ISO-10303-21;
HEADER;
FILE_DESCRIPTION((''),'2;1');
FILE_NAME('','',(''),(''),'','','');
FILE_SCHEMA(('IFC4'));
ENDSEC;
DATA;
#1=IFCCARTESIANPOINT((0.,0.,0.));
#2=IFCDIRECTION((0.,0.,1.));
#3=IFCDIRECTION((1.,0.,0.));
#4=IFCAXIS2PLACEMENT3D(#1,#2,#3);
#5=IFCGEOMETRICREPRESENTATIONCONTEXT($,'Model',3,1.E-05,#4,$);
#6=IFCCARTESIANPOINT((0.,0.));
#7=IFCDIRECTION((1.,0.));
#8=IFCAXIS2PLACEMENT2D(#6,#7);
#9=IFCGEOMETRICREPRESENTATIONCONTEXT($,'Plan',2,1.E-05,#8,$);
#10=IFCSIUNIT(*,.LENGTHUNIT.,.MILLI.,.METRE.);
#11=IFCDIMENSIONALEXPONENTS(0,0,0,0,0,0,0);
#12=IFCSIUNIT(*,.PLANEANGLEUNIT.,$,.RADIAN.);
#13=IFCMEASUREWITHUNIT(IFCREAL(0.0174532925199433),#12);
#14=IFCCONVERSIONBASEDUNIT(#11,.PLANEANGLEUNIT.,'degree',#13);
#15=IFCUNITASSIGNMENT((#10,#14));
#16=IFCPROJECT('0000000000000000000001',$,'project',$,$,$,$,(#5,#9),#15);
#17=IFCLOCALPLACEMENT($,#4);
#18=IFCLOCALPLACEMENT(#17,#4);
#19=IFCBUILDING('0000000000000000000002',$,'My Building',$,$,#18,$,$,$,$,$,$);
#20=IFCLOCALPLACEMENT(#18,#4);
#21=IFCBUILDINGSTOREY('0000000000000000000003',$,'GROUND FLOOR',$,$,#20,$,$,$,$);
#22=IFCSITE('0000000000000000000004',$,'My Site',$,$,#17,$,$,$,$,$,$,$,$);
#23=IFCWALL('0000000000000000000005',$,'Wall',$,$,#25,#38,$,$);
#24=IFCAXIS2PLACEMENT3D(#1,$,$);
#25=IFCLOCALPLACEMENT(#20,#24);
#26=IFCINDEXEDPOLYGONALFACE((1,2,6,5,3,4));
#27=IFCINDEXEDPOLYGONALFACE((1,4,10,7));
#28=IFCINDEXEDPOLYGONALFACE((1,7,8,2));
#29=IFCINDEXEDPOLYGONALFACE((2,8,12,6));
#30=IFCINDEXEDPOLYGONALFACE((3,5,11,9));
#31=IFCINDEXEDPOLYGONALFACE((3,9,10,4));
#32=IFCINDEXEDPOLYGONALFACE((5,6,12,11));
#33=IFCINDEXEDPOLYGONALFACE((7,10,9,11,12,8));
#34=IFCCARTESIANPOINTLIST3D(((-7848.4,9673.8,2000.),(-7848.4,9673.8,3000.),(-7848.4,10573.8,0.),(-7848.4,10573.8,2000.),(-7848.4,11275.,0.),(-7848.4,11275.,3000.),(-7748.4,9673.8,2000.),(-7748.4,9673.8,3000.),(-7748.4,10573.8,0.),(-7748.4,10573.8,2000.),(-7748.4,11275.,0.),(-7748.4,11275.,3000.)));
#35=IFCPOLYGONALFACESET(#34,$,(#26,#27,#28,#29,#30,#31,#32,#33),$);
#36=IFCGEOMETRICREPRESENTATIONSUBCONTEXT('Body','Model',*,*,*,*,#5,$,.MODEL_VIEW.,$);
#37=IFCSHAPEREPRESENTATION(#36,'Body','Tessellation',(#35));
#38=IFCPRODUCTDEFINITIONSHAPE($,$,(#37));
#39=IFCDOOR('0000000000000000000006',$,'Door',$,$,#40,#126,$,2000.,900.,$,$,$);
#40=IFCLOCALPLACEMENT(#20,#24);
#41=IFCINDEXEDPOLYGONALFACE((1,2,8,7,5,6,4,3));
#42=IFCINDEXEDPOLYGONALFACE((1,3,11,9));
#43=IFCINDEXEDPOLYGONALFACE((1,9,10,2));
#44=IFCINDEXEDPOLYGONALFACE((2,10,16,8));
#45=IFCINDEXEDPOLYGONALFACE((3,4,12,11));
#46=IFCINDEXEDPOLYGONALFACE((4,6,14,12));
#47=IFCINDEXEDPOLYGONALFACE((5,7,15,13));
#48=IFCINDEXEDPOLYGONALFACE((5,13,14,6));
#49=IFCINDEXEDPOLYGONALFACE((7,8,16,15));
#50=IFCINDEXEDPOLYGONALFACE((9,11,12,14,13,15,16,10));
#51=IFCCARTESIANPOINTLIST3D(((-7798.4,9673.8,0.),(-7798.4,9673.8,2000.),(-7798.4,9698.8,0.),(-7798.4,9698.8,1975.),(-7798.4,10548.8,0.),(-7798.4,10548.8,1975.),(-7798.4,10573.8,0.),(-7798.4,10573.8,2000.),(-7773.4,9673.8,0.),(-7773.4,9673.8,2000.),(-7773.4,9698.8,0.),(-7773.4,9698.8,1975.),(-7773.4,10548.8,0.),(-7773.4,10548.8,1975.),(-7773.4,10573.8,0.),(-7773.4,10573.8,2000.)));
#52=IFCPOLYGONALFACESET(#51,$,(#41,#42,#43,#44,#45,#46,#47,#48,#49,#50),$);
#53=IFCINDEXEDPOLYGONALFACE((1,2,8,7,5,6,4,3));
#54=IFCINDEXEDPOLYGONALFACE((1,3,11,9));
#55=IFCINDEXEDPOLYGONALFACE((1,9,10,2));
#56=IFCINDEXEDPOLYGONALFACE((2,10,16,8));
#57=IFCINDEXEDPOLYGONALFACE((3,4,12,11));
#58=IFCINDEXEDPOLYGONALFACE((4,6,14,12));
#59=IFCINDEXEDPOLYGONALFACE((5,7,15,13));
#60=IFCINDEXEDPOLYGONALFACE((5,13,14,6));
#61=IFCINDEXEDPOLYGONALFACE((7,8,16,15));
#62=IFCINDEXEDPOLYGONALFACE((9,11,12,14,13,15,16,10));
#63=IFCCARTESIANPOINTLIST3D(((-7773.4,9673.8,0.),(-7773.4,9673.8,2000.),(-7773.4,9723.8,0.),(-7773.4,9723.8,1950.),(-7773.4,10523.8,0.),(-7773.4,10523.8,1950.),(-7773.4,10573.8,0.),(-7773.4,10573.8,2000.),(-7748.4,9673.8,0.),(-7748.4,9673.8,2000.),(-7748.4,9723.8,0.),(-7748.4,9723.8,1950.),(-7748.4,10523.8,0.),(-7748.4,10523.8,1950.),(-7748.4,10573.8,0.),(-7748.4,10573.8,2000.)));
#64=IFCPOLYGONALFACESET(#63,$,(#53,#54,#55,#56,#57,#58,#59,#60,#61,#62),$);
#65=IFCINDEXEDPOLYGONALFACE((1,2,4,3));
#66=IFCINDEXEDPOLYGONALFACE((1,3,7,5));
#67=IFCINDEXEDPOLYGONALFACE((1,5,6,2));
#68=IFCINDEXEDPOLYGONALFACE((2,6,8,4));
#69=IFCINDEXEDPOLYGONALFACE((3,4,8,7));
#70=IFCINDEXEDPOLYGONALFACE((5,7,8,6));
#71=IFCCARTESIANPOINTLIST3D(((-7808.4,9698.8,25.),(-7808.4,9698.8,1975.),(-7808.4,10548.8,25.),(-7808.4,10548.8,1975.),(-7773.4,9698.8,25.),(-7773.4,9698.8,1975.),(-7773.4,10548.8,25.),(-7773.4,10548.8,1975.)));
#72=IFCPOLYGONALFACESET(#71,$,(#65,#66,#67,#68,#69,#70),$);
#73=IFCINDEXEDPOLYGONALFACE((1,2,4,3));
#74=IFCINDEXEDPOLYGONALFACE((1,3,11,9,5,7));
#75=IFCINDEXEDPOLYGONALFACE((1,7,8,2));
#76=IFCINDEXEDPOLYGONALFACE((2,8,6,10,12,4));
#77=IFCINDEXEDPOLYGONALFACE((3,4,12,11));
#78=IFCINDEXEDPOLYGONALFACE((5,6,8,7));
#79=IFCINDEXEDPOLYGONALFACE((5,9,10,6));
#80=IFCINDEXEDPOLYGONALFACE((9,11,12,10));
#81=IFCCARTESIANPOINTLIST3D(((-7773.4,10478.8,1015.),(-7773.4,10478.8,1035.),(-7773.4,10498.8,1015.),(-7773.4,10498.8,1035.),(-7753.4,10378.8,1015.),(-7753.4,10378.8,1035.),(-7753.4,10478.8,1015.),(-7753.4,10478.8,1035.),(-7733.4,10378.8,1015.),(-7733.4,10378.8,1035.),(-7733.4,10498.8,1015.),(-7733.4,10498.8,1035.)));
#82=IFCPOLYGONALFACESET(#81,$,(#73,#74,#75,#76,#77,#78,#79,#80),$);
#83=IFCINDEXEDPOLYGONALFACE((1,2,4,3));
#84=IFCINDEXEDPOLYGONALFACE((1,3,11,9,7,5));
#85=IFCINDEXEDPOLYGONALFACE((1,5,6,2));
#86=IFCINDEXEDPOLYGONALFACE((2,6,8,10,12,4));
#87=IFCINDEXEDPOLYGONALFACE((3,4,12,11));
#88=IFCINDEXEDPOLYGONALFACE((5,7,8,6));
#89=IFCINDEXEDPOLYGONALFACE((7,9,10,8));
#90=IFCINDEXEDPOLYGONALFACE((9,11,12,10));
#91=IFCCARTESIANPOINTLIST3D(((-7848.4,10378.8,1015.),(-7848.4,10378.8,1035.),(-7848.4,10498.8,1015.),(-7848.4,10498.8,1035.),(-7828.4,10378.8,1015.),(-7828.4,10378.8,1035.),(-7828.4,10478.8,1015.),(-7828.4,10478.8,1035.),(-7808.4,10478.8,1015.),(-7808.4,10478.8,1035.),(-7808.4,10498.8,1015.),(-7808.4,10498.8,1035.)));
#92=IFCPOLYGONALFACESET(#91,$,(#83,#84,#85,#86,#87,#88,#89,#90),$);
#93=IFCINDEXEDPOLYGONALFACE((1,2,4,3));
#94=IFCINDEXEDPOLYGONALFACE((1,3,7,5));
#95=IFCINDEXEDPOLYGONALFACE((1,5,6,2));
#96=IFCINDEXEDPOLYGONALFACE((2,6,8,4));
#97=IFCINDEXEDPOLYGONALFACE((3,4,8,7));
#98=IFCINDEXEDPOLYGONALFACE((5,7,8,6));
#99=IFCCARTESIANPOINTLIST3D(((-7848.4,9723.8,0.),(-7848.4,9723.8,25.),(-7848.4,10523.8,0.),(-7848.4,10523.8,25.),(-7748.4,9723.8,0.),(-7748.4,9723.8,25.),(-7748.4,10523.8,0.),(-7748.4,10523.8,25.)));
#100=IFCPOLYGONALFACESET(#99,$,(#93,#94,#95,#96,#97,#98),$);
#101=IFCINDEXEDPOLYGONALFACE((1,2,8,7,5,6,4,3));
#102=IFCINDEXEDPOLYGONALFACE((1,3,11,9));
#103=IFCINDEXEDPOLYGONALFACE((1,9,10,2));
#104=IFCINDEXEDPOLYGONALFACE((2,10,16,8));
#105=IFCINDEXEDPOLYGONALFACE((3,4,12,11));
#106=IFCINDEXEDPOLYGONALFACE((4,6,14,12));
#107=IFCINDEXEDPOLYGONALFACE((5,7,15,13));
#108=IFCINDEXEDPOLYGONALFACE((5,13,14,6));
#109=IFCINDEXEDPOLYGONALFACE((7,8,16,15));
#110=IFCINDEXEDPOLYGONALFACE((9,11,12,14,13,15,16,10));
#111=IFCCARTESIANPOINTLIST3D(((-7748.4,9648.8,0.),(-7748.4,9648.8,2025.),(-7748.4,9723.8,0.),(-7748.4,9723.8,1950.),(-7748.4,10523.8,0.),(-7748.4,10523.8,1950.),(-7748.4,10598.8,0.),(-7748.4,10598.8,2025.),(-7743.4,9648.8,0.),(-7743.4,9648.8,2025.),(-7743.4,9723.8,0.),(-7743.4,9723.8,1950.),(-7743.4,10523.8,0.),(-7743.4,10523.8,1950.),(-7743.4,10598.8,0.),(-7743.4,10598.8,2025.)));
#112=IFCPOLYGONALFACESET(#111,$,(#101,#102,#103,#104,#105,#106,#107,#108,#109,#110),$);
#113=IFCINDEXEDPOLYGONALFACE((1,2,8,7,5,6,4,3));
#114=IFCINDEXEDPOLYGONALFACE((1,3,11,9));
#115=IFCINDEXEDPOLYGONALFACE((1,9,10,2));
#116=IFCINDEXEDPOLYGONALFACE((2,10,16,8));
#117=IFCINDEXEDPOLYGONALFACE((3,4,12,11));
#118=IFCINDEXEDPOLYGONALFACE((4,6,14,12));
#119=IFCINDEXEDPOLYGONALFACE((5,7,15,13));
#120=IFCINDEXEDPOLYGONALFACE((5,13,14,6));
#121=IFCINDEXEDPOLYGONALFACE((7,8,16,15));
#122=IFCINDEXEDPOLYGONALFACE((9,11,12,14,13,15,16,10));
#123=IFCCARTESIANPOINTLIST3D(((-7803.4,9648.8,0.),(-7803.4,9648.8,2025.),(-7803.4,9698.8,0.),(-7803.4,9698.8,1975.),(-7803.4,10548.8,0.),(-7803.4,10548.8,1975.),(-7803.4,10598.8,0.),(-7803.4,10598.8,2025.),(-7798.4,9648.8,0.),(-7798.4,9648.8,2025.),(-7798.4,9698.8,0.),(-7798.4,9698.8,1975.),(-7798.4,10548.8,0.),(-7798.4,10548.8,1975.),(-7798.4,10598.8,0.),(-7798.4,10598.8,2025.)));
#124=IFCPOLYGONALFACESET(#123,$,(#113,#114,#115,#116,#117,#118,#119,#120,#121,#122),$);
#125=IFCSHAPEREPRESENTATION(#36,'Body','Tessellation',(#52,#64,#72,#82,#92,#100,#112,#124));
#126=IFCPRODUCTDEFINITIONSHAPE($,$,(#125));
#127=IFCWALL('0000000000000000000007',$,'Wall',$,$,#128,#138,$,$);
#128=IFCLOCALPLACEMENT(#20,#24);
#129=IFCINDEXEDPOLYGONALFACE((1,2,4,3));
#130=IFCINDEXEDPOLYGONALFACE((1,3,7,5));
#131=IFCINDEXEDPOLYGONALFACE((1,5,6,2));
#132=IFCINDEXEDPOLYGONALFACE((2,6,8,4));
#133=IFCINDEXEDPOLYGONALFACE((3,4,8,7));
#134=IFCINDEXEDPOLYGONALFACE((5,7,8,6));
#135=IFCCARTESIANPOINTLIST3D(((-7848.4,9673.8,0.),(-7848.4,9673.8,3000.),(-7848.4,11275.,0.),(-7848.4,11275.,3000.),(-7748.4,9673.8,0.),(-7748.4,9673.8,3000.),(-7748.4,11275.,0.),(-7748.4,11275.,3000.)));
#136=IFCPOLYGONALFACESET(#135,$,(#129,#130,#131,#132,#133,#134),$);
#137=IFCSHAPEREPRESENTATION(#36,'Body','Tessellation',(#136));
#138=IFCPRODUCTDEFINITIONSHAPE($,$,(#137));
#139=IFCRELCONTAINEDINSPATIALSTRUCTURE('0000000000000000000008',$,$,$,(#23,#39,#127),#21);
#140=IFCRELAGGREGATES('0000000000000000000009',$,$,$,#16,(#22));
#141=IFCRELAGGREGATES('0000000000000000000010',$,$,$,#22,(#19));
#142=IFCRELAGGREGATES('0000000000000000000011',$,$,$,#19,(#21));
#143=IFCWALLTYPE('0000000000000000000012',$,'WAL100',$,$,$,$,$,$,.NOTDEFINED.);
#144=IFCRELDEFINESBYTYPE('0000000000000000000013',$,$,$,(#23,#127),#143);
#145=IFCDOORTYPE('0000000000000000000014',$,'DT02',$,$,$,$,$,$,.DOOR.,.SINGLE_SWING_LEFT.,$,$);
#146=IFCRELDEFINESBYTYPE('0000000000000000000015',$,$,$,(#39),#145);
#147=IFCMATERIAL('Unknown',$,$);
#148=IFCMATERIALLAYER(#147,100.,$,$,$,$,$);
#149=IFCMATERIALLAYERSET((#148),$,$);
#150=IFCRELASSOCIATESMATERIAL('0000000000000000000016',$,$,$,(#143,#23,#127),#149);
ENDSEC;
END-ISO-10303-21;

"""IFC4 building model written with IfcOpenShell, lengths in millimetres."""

from ifc_helpers import new_model, entity, si_unit, converted_unit, frame, origin_with_axes, origin_2d_with_axis, place, context, subcontext, project, spatial, line, indexed_curve, outline, extrude, shape, source, transform, mapped, material, layer, layer_set, layer_usage, type_object, type_shapes, element, fill, save


model = new_model("IFC4")

# Units and contexts
model_context = context("Model", 3, precision=1e-05, world=origin_with_axes())
plan_context = context("Plan", 2, precision=1e-05, world=origin_2d_with_axis())
body_context_1 = subcontext(model_context, "Body", "Model", "MODEL_VIEW")
body_context_2 = subcontext(plan_context, "Body", "Plan", "PLAN_VIEW")
ifc_project = project(units=[si_unit("LENGTHUNIT", "METRE", prefix="MILLI"), converted_unit("PLANEANGLEUNIT", "degree", entity("IfcReal", 0.0174532925199433), si_unit("PLANEANGLEUNIT", "RADIAN"), dimensions=[0, 0, 0, 0, 0, 0, 0])], contexts=[model_context, plan_context])

# Site, building, storey
site_placement = place(None, origin_with_axes())
site = spatial("IfcSite", under=ifc_project, at=site_placement, Name="My Site")
building_placement = place(site_placement, origin_with_axes())
building = spatial("IfcBuilding", under=site, at=building_placement, Name="My Building")
storey_placement = place(building_placement, origin_with_axes())
storey = spatial("IfcBuildingStorey", under=building, at=storey_placement, Name="GROUND FLOOR")

# Shared definitions
ifc_material_1 = material(Name="Unknown")
ifc_layer_1 = layer(ifc_material_1, 100.0)
ifc_layer_set_1 = layer_set([ifc_layer_1])
wall_type_1 = type_object("IfcWallType", Name="WAL100", PredefinedType="NOTDEFINED", material=ifc_layer_set_1)

# Wall, opening, door
shared_shape_1 = source(origin_with_axes(), body_context_1, "Body", "SweptSolid", [
    extrude(outline(indexed_curve([(0.0, 0.0), (900.0, 0.0), (900.0, 2000.0), (0.0, 2000.0)], segments=[line(1, 2), line(2, 3), line(3, 4), line(4, 1)])), frame((0.0, -100.0, 0.0), z_axis=(0.0, -1.0, 0.0), x_axis=(1.0, 0.0, 0.0)), (0.0, 0.0, -1.0), 300.0),
])
door_type = type_object("IfcDoorType", Name="DT02", OperationType="SINGLE_SWING_LEFT", PredefinedType="DOOR")
shared_shape_2 = source(origin_with_axes(), body_context_1, "Body", "SweptSolid", [
    extrude(outline(indexed_curve([(0.0, 0.0), (0.0, 2000.0), (900.0, 2000.0), (900.0, 0.0), (875.0, 0.0), (875.0, 1975.0), (25.0, 1975.0), (25.0, 0.0)], segments=[line(1, 2), line(2, 3), line(3, 4), line(4, 5), line(5, 6), line(6, 7), line(7, 8), line(8, 1)])), frame((0.0, 25.0, 0.0), z_axis=(0.0, -1.0, 0.0), x_axis=(1.0, 0.0, 0.0)), (0.0, 0.0, -1.0), 25.0),
    extrude(outline(indexed_curve([(0.0, 0.0), (0.0, 2000.0), (900.0, 2000.0), (900.0, 0.0), (850.0, 0.0), (850.0, 1950.0), (50.0, 1950.0), (50.0, 0.0)], segments=[line(1, 2), line(2, 3), line(3, 4), line(4, 5), line(5, 6), line(6, 7), line(7, 8), line(8, 1)])), frame((0.0, 0.0, 0.0), z_axis=(0.0, -1.0, 0.0), x_axis=(1.0, 0.0, 0.0)), (0.0, 0.0, -1.0), 25.0),
    extrude(outline(indexed_curve([(0.0, 0.0), (850.0, 0.0), (850.0, 35.0), (0.0, 35.0)], segments=[line(1, 2), line(2, 3), line(3, 4), line(4, 1)])), frame((25.0, 25.0, 25.0), z_axis=(0.0, 0.0, 1.0), x_axis=(1.0, 0.0, 0.0)), (0.0, 0.0, 1.0), 1950.0),
    extrude(outline(indexed_curve([(0.0, 0.0), (0.0, -40.0), (-120.0, -40.0), (-120.0, -20.0), (-20.0, -20.0), (-20.0, 0.0)], segments=[line(1, 2), line(2, 3), line(3, 4), line(4, 5), line(5, 6), line(6, 1)])), frame((825.0, 25.0, 1015.0), z_axis=(0.0, 0.0, 1.0), x_axis=(1.0, 0.0, 0.0)), (0.0, 0.0, 1.0), 20.0),
    extrude(outline(indexed_curve([(0.0, 0.0), (0.0, 40.0), (-120.0, 40.0), (-120.0, 20.0), (-20.0, 20.0), (-20.0, 0.0)], segments=[line(1, 2), line(2, 3), line(3, 4), line(4, 5), line(5, 6), line(6, 1)])), frame((825.0, 60.0, 1015.0), z_axis=(0.0, 0.0, 1.0), x_axis=(1.0, 0.0, 0.0)), (0.0, 0.0, 1.0), 20.0),
    extrude(outline(indexed_curve([(0.0, 0.0), (800.0, 0.0), (800.0, 100.0), (0.0, 100.0)], segments=[line(1, 2), line(2, 3), line(3, 4), line(4, 1)])), frame((50.0, 0.0, 0.0), z_axis=(0.0, 0.0, 1.0), x_axis=(1.0, 0.0, 0.0)), (0.0, 0.0, 1.0), 25.0),
    extrude(outline(indexed_curve([(0.0, 0.0), (0.0, 2025.0), (950.0, 2025.0), (950.0, 0.0), (875.0, 0.0), (875.0, 1950.0), (75.0, 1950.0), (75.0, 0.0)], segments=[line(1, 2), line(2, 3), line(3, 4), line(4, 5), line(5, 6), line(6, 7), line(7, 8), line(8, 1)])), frame((-25.0, -5.0, 0.0), z_axis=(0.0, -1.0, 0.0), x_axis=(1.0, 0.0, 0.0)), (0.0, 0.0, -1.0), 5.0),
    extrude(outline(indexed_curve([(0.0, 0.0), (0.0, 2025.0), (950.0, 2025.0), (950.0, 0.0), (900.0, 0.0), (900.0, 1975.0), (50.0, 1975.0), (50.0, 0.0)], segments=[line(1, 2), line(2, 3), line(3, 4), line(4, 5), line(5, 6), line(6, 7), line(7, 8), line(8, 1)])), frame((-25.0, 50.0, 0.0), z_axis=(0.0, -1.0, 0.0), x_axis=(1.0, 0.0, 0.0)), (0.0, 0.0, -1.0), 5.0),
])
shared_shape_3 = source(origin_with_axes(), body_context_2, "Body", "Curve2D", [
    entity("IfcIndexedPolyCurve", entity("IfcCartesianPointList2D", [[0.0, 0.0], [0.0, 50.0], [25.0, 50.0], [25.0, 25.0], [50.0, 25.0], [50.0, 0.0]]), [entity("IfcLineIndex", [1, 2]), entity("IfcLineIndex", [2, 3]), entity("IfcLineIndex", [3, 4]), entity("IfcLineIndex", [4, 5]), entity("IfcLineIndex", [5, 6]), entity("IfcLineIndex", [6, 1])]),
    entity("IfcIndexedPolyCurve", entity("IfcCartesianPointList2D", [[900.0, 0.0], [900.0, 50.0], [875.0, 50.0], [875.0, 25.0], [850.0, 25.0], [850.0, 0.0]]), [entity("IfcLineIndex", [1, 2]), entity("IfcLineIndex", [2, 3]), entity("IfcLineIndex", [3, 4]), entity("IfcLineIndex", [4, 5]), entity("IfcLineIndex", [5, 6]), entity("IfcLineIndex", [6, 1])]),
    entity("IfcTrimmedCurve", entity("IfcEllipse", entity("IfcAxis2Placement2D", entity("IfcCartesianPoint", [60.0, 50.0]), entity("IfcDirection", [1.0, 0.0])), 815.0, 850.0), [entity("IfcCartesianPoint", [875.0, 50.0])], [entity("IfcCartesianPoint", [60.0, 900.0])], True, "CARTESIAN"),
    entity("IfcIndexedPolyCurve", entity("IfcCartesianPointList2D", [[25.0, 50.0], [60.0, 50.0], [60.0, 900.0], [25.0, 900.0]]), [entity("IfcLineIndex", [1, 2]), entity("IfcLineIndex", [2, 3]), entity("IfcLineIndex", [3, 4]), entity("IfcLineIndex", [4, 1])]),
])
type_shapes(door_type, [shared_shape_2, shared_shape_3])
ifc_layer_usage_1 = layer_usage(ifc_layer_set_1, "AXIS2", "POSITIVE", 0.0)
wall_1_placement = place(storey_placement, frame((-7748.4, 9673.8, 0.0), z_axis=(0.0, 0.0, 1.0), x_axis=(0.000001, 1.0, 0.0)))
wall_1 = element("IfcWall", 1, at=wall_1_placement, inside=storey, type_object=wall_type_1, material=ifc_layer_usage_1, Name="Wall", context=body_context_1, shape_type="SweptSolid", body=[
    extrude(outline(indexed_curve([(0.0, 0.0), (0.0, 100.0), (1601.2, 100.0), (1601.2, 0.0), (0.0, 0.0)], self_intersect=False)), origin_with_axes(), (0.0, 0.0, 1.0), 3000.0),
])
opening_1_placement = place(wall_1_placement, frame((0.0, 0.0, 0.0), z_axis=(0.0, 0.0, 1.0), x_axis=(1.0, 0.0, 0.0)))
opening_1 = element("IfcOpeningElement", 2, at=opening_1_placement, cuts=wall_1, PredefinedType="OPENING", context=body_context_1, shape_type="MappedRepresentation", body=[
    mapped(shared_shape_1, transform((0.0, 0.0, 0.0), x_axis=(1.0, 0.0, 0.0), y_axis=(0.0, 1.0, 0.0), z_axis=(0.0, 0.0, 1.0), scale=1.0)),
])
door_1_placement = place(opening_1_placement, frame((0.0, 0.0, 0.0), z_axis=(0.0, 0.0, 1.0), x_axis=(1.0, 0.0, 0.0)))
door_1 = element("IfcDoor", 3, at=door_1_placement, inside=storey, type_object=door_type, Name="Door", OverallHeight=2000.0, OverallWidth=900.0, shapes=[
    shape(body_context_1, "Body", "MappedRepresentation", [mapped(shared_shape_2, transform((0.0, 0.0, 0.0), x_axis=(1.0, 0.0, 0.0), y_axis=(0.0, 1.0, 0.0), z_axis=(0.0, 0.0, 1.0), scale=1.0))]),
    shape(body_context_2, "Body", "MappedRepresentation", [mapped(shared_shape_3, transform((0.0, 0.0, 0.0), x_axis=(1.0, 0.0, 0.0), y_axis=(0.0, 1.0, 0.0), z_axis=(0.0, 0.0, 1.0), scale=1.0))]),
])
fill(opening_1, door_1)

# Wall
ifc_layer_usage_2 = layer_usage(ifc_layer_set_1, "AXIS2", "POSITIVE", 0.0)
wall_2_placement = place(storey_placement, frame((-7748.4, 9673.8, 0.0), z_axis=(0.0, 0.0, 1.0), x_axis=(0.000001, 1.0, 0.0)))
element("IfcWall", 4, at=wall_2_placement, inside=storey, type_object=wall_type_1, material=ifc_layer_usage_2, Name="Wall", context=body_context_1, shape_type="SweptSolid", body=[
    extrude(outline(indexed_curve([(0.0, 0.0), (0.0, 100.0), (1601.2, 100.0), (1601.2, 0.0), (0.0, 0.0)], self_intersect=False)), origin_with_axes(), (0.0, 0.0, 1.0), 3000.0),
])

save(model, "model.ifc")
